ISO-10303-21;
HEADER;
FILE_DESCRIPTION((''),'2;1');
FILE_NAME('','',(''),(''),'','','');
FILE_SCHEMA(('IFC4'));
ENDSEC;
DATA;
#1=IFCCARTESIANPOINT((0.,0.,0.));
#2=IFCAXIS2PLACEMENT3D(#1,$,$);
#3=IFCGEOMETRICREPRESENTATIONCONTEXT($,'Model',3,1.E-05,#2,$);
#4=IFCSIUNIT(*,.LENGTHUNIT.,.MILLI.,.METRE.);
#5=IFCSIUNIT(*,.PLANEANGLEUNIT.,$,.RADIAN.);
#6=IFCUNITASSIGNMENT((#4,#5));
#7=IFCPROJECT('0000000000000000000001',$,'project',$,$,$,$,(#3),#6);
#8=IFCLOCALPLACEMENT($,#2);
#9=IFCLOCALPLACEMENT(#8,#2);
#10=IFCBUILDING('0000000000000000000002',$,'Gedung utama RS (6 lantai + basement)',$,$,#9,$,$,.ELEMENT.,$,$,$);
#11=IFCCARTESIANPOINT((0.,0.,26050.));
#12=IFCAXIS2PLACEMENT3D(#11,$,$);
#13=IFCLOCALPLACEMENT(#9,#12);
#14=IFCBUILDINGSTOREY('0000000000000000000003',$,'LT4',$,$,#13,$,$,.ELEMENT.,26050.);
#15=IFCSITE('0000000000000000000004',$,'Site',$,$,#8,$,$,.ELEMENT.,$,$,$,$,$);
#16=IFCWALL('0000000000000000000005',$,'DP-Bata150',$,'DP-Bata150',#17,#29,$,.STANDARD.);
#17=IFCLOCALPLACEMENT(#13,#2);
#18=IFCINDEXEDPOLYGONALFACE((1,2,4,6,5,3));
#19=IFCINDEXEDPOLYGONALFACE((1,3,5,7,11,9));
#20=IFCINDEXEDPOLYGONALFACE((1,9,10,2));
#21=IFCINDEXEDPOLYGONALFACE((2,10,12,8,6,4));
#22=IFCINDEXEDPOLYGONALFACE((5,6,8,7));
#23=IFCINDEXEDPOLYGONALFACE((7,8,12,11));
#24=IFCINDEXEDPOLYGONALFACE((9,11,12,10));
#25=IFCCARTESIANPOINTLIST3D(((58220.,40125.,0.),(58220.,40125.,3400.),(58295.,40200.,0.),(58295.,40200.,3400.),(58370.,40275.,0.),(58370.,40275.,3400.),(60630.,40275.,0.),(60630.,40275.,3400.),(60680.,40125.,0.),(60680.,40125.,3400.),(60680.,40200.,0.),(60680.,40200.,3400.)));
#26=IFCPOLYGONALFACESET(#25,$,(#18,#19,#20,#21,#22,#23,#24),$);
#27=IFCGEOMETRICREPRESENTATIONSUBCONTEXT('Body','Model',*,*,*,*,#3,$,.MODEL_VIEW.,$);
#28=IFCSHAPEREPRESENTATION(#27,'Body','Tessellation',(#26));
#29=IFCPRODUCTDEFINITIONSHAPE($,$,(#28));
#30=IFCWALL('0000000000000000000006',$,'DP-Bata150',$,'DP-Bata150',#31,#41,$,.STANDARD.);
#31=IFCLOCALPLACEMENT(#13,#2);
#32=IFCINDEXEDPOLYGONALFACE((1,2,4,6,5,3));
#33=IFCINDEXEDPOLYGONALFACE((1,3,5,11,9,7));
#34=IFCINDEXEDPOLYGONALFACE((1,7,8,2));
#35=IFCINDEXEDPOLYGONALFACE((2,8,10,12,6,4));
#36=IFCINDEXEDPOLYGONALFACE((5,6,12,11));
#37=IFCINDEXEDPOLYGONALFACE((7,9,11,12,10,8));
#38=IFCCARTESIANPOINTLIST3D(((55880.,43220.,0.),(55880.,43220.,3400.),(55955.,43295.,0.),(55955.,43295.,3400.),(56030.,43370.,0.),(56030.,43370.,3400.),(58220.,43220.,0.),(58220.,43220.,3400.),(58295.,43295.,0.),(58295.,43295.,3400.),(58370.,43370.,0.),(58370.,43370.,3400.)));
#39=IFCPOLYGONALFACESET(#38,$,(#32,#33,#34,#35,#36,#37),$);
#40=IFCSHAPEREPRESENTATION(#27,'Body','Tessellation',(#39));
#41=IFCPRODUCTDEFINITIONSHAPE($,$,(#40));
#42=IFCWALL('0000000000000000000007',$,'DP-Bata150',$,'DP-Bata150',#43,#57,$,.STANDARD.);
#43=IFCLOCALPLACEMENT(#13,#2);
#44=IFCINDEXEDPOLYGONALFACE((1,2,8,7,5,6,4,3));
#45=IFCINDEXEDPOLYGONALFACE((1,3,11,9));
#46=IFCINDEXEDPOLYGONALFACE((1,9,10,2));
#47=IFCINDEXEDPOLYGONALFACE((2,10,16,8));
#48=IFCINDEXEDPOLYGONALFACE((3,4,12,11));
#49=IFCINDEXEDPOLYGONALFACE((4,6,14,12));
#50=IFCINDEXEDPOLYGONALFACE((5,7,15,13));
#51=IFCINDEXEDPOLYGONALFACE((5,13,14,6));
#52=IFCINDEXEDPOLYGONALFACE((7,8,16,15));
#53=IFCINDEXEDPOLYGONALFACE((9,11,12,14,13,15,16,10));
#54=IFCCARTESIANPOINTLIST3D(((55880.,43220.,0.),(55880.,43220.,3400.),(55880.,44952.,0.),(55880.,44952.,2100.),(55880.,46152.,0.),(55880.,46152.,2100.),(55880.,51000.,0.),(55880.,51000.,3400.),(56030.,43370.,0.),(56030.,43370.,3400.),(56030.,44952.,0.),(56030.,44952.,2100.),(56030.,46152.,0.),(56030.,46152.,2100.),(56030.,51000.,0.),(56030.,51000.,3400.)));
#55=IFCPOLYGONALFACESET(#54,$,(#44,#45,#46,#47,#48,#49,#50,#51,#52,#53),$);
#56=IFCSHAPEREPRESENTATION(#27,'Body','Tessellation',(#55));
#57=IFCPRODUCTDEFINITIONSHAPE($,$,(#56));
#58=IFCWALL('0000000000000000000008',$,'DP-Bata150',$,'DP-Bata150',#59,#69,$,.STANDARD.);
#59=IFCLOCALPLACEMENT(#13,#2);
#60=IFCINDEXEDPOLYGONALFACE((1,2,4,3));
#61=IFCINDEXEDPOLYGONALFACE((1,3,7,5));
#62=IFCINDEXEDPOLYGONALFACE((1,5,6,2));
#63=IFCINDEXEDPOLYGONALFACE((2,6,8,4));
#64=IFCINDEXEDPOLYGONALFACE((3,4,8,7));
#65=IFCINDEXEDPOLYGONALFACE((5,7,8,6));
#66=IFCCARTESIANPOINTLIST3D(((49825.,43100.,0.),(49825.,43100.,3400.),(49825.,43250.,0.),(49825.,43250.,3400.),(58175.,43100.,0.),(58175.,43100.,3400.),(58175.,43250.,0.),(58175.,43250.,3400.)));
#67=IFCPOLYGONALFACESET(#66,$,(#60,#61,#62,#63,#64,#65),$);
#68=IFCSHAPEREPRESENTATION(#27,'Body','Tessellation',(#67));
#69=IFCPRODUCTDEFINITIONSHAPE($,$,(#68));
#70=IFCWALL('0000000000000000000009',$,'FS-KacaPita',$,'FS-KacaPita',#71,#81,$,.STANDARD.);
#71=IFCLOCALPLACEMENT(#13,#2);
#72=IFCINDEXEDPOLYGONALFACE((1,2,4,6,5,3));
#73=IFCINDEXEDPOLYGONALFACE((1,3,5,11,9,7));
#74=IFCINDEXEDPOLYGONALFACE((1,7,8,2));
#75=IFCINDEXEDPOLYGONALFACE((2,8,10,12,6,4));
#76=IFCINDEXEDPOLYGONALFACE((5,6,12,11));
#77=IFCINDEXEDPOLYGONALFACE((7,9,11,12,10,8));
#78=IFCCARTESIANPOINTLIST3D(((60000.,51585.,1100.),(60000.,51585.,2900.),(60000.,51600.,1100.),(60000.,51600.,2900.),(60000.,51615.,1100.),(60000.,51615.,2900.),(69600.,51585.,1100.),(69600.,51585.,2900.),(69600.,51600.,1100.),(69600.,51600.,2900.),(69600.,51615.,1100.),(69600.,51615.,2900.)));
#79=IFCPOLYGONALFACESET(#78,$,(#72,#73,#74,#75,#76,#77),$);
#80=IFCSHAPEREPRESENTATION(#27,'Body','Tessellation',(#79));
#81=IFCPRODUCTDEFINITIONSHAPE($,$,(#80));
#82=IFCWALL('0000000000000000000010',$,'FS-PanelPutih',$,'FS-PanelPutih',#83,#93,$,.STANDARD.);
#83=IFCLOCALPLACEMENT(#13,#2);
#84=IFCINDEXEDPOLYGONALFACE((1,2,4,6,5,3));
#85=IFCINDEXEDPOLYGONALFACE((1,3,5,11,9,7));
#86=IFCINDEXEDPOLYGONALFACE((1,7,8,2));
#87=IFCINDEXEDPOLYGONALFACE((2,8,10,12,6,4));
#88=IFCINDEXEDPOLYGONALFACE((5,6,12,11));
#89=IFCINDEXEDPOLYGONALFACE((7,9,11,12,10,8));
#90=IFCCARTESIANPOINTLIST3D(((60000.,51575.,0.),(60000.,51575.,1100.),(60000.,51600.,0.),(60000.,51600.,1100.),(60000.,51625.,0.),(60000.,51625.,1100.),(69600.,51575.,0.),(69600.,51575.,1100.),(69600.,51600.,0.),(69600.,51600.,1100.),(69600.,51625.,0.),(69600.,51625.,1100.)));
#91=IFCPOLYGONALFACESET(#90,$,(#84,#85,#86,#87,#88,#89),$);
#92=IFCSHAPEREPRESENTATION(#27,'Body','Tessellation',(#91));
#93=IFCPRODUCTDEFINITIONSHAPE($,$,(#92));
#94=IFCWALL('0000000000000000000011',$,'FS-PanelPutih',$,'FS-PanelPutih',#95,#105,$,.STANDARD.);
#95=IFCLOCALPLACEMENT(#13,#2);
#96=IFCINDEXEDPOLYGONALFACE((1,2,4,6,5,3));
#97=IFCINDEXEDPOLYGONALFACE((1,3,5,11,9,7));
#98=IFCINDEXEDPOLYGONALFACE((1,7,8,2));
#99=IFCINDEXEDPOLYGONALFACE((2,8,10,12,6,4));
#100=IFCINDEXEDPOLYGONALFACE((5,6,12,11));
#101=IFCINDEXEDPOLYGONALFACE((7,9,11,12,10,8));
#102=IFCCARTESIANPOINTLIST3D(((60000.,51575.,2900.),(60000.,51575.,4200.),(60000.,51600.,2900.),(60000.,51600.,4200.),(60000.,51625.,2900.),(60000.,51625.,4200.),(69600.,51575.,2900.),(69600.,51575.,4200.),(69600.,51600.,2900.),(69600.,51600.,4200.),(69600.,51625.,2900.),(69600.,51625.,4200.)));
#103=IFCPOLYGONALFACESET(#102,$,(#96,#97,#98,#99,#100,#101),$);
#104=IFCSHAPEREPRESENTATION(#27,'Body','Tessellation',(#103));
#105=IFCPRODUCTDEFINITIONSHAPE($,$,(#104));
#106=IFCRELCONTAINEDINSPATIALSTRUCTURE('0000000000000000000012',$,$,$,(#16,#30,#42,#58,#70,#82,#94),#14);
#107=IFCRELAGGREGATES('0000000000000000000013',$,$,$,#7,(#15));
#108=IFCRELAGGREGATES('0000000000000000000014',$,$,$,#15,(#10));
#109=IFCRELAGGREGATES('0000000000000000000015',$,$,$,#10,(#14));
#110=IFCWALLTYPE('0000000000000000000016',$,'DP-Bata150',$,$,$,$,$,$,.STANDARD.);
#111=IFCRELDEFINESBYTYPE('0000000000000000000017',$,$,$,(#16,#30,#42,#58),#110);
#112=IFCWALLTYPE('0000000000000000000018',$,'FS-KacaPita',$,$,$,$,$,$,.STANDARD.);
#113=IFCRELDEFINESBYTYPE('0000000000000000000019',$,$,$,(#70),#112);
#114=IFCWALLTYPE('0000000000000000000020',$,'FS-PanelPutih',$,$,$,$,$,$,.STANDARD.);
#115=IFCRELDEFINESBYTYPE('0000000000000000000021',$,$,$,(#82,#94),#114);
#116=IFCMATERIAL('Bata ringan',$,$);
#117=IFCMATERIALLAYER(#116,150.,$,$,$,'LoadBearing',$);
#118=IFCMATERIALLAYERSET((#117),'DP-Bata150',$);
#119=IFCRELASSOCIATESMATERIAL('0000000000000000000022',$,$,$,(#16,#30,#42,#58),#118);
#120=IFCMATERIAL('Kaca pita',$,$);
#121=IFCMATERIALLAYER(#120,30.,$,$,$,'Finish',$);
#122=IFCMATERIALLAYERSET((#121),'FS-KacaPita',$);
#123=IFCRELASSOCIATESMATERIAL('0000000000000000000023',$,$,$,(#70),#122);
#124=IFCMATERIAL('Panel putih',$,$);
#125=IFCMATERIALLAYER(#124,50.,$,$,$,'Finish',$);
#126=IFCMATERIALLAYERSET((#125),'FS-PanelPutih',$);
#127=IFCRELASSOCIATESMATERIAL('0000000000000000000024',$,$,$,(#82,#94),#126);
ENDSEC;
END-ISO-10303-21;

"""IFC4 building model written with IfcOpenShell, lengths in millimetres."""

from ifc_helpers import new_model, si_unit, frame, frame_2d, origin, place, context, subcontext, project, spatial, polyline, rectangle, outline, extrude, material, layer, layer_set, layer_usage, type_object, element, save


model = new_model("IFC4")

# Units and contexts
model_context = context("Model", 3, precision=1e-05, world=origin())
body_context = subcontext(model_context, "Body", "Model", "MODEL_VIEW")
ifc_project = project(units=[si_unit("LENGTHUNIT", "METRE", prefix="MILLI"), si_unit("PLANEANGLEUNIT", "RADIAN")], contexts=[model_context])

# Site, building, storey
site_placement = place(None, origin())
site = spatial("IfcSite", under=ifc_project, at=site_placement, Name="Site", CompositionType="ELEMENT")
building_placement = place(site_placement, origin())
building = spatial("IfcBuilding", under=site, at=building_placement, Name="Gedung utama RS (6 lantai + basement)", CompositionType="ELEMENT")
storey_placement = place(building_placement, frame((0.0, 0.0, 26050.0)))
storey = spatial("IfcBuildingStorey", under=building, at=storey_placement, Name="LT4", CompositionType="ELEMENT", Elevation=26050.0)

# Walls
ifc_material_1 = material(Name="Bata ringan")
ifc_layer_1 = layer(ifc_material_1, 150.0, Category="LoadBearing")
ifc_layer_set_1 = layer_set([ifc_layer_1], Name="DP-Bata150")
ifc_layer_usage_1 = layer_usage(ifc_layer_set_1, "AXIS2", "NEGATIVE", 75.0)
wall_type_1 = type_object("IfcWallType", Name="DP-Bata150", PredefinedType="STANDARD")
wall_1_placement = place(storey_placement, frame((60680.0, 40200.0, 0.0), z_axis=(0.0, 0.0, 1.0), x_axis=(-1.0, 0.0, 0.0)))
element("IfcWall", 1, at=wall_1_placement, inside=storey, type_object=wall_type_1, material=ifc_layer_usage_1, Name="DP-Bata150", ObjectType="DP-Bata150", PredefinedType="STANDARD", context=body_context, shape_type="SweptSolid", body=[
    extrude(outline(polyline([(50.0, -75.0), (0.0, 0.0), (0.0, 75.0), (2460.0, 75.0), (2385.0, 0.0), (2310.0, -75.0), (50.0, -75.0)])), origin(), (0.0, 0.0, 1.0), 3400.0),
])
wall_2_placement = place(storey_placement, frame((58295.0, 43295.0, 0.0), z_axis=(0.0, 0.0, 1.0), x_axis=(-1.0, 0.0, 0.0)))
element("IfcWall", 2, at=wall_2_placement, inside=storey, type_object=wall_type_1, material=ifc_layer_usage_1, Name="DP-Bata150", ObjectType="DP-Bata150", PredefinedType="STANDARD", context=body_context, shape_type="SweptSolid", body=[
    extrude(outline(polyline([(-75.0, -75.0), (0.0, 0.0), (75.0, 75.0), (2415.0, 75.0), (2340.0, 0.0), (2265.0, -75.0), (-75.0, -75.0)])), origin(), (0.0, 0.0, 1.0), 3400.0),
])

# Wall, opening
wall_3_placement = place(storey_placement, frame((55955.0, 43295.0, 0.0), z_axis=(0.0, 0.0, 1.0), x_axis=(0.0, 1.0, 0.0)))
wall_3 = element("IfcWall", 3, at=wall_3_placement, inside=storey, type_object=wall_type_1, material=ifc_layer_usage_1, Name="DP-Bata150", ObjectType="DP-Bata150", PredefinedType="STANDARD", context=body_context, shape_type="SweptSolid", body=[
    extrude(outline(polyline([(75.0, -75.0), (0.0, 0.0), (-75.0, 75.0), (7705.0, 75.0), (7705.0, -75.0), (75.0, -75.0)])), origin(), (0.0, 0.0, 1.0), 3400.0),
])
opening_placement = place(wall_3_placement, frame((1657.0, 0.0, 0.0), z_axis=(0.0, 0.0, 1.0), x_axis=(1.0, 0.0, 0.0)))
element("IfcOpeningElement", 4, at=opening_placement, cuts=wall_3, PredefinedType="OPENING", context=body_context, shape_type="SweptSolid", body=[
    extrude(rectangle(XDim=1200.0, YDim=170.0, at=frame_2d((600.0, 0.0))), origin(), (0.0, 0.0, 1.0), 2100.0),
])

# Walls
wall_4_placement = place(storey_placement, frame((58175.0, 43175.0, 0.0), z_axis=(0.0, 0.0, 1.0), x_axis=(-1.0, 0.0, 0.0)))
element("IfcWall", 5, at=wall_4_placement, inside=storey, type_object=wall_type_1, material=ifc_layer_usage_1, Name="DP-Bata150", ObjectType="DP-Bata150", PredefinedType="STANDARD", context=body_context, shape_type="SweptSolid", body=[
    extrude(outline(polyline([(0.0, -75.0), (0.0, 75.0), (8350.0, 75.0), (8350.0, -75.0), (0.0, -75.0)])), origin(), (0.0, 0.0, 1.0), 3400.0),
])
ifc_material_2 = material(Name="Kaca pita")
ifc_layer_2 = layer(ifc_material_2, 30.0, Category="Finish")
ifc_layer_set_2 = layer_set([ifc_layer_2], Name="FS-KacaPita")
ifc_layer_usage_2 = layer_usage(ifc_layer_set_2, "AXIS2", "NEGATIVE", 15.0)
wall_type_2 = type_object("IfcWallType", Name="FS-KacaPita", PredefinedType="STANDARD")
wall_5_placement = place(storey_placement, frame((60000.0, 51600.0, 1100.0), z_axis=(0.0, 0.0, 1.0), x_axis=(1.0, 0.0, 0.0)))
element("IfcWall", 6, at=wall_5_placement, inside=storey, type_object=wall_type_2, material=ifc_layer_usage_2, Name="FS-KacaPita", ObjectType="FS-KacaPita", PredefinedType="STANDARD", context=body_context, shape_type="SweptSolid", body=[
    extrude(outline(polyline([(0.0, -15.0), (0.0, 0.0), (0.0, 15.0), (9600.0, 15.0), (9600.0, 0.0), (9600.0, -15.0), (0.0, -15.0)])), origin(), (0.0, 0.0, 1.0), 1800.0),
])
ifc_material_3 = material(Name="Panel putih")
ifc_layer_3 = layer(ifc_material_3, 50.0, Category="Finish")
ifc_layer_set_3 = layer_set([ifc_layer_3], Name="FS-PanelPutih")
ifc_layer_usage_3 = layer_usage(ifc_layer_set_3, "AXIS2", "NEGATIVE", 25.0)
wall_type_3 = type_object("IfcWallType", Name="FS-PanelPutih", PredefinedType="STANDARD")
wall_6_placement = place(storey_placement, frame((60000.0, 51600.0, 0.0), z_axis=(0.0, 0.0, 1.0), x_axis=(1.0, 0.0, 0.0)))
element("IfcWall", 7, at=wall_6_placement, inside=storey, type_object=wall_type_3, material=ifc_layer_usage_3, Name="FS-PanelPutih", ObjectType="FS-PanelPutih", PredefinedType="STANDARD", context=body_context, shape_type="SweptSolid", body=[
    extrude(outline(polyline([(0.0, -25.0), (0.0, 0.0), (0.0, 25.0), (9600.0, 25.0), (9600.0, 0.0), (9600.0, -25.0), (0.0, -25.0)])), origin(), (0.0, 0.0, 1.0), 1100.0),
])
wall_7_placement = place(storey_placement, frame((60000.0, 51600.0, 2900.0), z_axis=(0.0, 0.0, 1.0), x_axis=(1.0, 0.0, 0.0)))
element("IfcWall", 8, at=wall_7_placement, inside=storey, type_object=wall_type_3, material=ifc_layer_usage_3, Name="FS-PanelPutih", ObjectType="FS-PanelPutih", PredefinedType="STANDARD", context=body_context, shape_type="SweptSolid", body=[
    extrude(outline(polyline([(0.0, -25.0), (0.0, 0.0), (0.0, 25.0), (9600.0, 25.0), (9600.0, 0.0), (9600.0, -25.0), (0.0, -25.0)])), origin(), (0.0, 0.0, 1.0), 1300.0),
])

save(model, "model.ifc")
